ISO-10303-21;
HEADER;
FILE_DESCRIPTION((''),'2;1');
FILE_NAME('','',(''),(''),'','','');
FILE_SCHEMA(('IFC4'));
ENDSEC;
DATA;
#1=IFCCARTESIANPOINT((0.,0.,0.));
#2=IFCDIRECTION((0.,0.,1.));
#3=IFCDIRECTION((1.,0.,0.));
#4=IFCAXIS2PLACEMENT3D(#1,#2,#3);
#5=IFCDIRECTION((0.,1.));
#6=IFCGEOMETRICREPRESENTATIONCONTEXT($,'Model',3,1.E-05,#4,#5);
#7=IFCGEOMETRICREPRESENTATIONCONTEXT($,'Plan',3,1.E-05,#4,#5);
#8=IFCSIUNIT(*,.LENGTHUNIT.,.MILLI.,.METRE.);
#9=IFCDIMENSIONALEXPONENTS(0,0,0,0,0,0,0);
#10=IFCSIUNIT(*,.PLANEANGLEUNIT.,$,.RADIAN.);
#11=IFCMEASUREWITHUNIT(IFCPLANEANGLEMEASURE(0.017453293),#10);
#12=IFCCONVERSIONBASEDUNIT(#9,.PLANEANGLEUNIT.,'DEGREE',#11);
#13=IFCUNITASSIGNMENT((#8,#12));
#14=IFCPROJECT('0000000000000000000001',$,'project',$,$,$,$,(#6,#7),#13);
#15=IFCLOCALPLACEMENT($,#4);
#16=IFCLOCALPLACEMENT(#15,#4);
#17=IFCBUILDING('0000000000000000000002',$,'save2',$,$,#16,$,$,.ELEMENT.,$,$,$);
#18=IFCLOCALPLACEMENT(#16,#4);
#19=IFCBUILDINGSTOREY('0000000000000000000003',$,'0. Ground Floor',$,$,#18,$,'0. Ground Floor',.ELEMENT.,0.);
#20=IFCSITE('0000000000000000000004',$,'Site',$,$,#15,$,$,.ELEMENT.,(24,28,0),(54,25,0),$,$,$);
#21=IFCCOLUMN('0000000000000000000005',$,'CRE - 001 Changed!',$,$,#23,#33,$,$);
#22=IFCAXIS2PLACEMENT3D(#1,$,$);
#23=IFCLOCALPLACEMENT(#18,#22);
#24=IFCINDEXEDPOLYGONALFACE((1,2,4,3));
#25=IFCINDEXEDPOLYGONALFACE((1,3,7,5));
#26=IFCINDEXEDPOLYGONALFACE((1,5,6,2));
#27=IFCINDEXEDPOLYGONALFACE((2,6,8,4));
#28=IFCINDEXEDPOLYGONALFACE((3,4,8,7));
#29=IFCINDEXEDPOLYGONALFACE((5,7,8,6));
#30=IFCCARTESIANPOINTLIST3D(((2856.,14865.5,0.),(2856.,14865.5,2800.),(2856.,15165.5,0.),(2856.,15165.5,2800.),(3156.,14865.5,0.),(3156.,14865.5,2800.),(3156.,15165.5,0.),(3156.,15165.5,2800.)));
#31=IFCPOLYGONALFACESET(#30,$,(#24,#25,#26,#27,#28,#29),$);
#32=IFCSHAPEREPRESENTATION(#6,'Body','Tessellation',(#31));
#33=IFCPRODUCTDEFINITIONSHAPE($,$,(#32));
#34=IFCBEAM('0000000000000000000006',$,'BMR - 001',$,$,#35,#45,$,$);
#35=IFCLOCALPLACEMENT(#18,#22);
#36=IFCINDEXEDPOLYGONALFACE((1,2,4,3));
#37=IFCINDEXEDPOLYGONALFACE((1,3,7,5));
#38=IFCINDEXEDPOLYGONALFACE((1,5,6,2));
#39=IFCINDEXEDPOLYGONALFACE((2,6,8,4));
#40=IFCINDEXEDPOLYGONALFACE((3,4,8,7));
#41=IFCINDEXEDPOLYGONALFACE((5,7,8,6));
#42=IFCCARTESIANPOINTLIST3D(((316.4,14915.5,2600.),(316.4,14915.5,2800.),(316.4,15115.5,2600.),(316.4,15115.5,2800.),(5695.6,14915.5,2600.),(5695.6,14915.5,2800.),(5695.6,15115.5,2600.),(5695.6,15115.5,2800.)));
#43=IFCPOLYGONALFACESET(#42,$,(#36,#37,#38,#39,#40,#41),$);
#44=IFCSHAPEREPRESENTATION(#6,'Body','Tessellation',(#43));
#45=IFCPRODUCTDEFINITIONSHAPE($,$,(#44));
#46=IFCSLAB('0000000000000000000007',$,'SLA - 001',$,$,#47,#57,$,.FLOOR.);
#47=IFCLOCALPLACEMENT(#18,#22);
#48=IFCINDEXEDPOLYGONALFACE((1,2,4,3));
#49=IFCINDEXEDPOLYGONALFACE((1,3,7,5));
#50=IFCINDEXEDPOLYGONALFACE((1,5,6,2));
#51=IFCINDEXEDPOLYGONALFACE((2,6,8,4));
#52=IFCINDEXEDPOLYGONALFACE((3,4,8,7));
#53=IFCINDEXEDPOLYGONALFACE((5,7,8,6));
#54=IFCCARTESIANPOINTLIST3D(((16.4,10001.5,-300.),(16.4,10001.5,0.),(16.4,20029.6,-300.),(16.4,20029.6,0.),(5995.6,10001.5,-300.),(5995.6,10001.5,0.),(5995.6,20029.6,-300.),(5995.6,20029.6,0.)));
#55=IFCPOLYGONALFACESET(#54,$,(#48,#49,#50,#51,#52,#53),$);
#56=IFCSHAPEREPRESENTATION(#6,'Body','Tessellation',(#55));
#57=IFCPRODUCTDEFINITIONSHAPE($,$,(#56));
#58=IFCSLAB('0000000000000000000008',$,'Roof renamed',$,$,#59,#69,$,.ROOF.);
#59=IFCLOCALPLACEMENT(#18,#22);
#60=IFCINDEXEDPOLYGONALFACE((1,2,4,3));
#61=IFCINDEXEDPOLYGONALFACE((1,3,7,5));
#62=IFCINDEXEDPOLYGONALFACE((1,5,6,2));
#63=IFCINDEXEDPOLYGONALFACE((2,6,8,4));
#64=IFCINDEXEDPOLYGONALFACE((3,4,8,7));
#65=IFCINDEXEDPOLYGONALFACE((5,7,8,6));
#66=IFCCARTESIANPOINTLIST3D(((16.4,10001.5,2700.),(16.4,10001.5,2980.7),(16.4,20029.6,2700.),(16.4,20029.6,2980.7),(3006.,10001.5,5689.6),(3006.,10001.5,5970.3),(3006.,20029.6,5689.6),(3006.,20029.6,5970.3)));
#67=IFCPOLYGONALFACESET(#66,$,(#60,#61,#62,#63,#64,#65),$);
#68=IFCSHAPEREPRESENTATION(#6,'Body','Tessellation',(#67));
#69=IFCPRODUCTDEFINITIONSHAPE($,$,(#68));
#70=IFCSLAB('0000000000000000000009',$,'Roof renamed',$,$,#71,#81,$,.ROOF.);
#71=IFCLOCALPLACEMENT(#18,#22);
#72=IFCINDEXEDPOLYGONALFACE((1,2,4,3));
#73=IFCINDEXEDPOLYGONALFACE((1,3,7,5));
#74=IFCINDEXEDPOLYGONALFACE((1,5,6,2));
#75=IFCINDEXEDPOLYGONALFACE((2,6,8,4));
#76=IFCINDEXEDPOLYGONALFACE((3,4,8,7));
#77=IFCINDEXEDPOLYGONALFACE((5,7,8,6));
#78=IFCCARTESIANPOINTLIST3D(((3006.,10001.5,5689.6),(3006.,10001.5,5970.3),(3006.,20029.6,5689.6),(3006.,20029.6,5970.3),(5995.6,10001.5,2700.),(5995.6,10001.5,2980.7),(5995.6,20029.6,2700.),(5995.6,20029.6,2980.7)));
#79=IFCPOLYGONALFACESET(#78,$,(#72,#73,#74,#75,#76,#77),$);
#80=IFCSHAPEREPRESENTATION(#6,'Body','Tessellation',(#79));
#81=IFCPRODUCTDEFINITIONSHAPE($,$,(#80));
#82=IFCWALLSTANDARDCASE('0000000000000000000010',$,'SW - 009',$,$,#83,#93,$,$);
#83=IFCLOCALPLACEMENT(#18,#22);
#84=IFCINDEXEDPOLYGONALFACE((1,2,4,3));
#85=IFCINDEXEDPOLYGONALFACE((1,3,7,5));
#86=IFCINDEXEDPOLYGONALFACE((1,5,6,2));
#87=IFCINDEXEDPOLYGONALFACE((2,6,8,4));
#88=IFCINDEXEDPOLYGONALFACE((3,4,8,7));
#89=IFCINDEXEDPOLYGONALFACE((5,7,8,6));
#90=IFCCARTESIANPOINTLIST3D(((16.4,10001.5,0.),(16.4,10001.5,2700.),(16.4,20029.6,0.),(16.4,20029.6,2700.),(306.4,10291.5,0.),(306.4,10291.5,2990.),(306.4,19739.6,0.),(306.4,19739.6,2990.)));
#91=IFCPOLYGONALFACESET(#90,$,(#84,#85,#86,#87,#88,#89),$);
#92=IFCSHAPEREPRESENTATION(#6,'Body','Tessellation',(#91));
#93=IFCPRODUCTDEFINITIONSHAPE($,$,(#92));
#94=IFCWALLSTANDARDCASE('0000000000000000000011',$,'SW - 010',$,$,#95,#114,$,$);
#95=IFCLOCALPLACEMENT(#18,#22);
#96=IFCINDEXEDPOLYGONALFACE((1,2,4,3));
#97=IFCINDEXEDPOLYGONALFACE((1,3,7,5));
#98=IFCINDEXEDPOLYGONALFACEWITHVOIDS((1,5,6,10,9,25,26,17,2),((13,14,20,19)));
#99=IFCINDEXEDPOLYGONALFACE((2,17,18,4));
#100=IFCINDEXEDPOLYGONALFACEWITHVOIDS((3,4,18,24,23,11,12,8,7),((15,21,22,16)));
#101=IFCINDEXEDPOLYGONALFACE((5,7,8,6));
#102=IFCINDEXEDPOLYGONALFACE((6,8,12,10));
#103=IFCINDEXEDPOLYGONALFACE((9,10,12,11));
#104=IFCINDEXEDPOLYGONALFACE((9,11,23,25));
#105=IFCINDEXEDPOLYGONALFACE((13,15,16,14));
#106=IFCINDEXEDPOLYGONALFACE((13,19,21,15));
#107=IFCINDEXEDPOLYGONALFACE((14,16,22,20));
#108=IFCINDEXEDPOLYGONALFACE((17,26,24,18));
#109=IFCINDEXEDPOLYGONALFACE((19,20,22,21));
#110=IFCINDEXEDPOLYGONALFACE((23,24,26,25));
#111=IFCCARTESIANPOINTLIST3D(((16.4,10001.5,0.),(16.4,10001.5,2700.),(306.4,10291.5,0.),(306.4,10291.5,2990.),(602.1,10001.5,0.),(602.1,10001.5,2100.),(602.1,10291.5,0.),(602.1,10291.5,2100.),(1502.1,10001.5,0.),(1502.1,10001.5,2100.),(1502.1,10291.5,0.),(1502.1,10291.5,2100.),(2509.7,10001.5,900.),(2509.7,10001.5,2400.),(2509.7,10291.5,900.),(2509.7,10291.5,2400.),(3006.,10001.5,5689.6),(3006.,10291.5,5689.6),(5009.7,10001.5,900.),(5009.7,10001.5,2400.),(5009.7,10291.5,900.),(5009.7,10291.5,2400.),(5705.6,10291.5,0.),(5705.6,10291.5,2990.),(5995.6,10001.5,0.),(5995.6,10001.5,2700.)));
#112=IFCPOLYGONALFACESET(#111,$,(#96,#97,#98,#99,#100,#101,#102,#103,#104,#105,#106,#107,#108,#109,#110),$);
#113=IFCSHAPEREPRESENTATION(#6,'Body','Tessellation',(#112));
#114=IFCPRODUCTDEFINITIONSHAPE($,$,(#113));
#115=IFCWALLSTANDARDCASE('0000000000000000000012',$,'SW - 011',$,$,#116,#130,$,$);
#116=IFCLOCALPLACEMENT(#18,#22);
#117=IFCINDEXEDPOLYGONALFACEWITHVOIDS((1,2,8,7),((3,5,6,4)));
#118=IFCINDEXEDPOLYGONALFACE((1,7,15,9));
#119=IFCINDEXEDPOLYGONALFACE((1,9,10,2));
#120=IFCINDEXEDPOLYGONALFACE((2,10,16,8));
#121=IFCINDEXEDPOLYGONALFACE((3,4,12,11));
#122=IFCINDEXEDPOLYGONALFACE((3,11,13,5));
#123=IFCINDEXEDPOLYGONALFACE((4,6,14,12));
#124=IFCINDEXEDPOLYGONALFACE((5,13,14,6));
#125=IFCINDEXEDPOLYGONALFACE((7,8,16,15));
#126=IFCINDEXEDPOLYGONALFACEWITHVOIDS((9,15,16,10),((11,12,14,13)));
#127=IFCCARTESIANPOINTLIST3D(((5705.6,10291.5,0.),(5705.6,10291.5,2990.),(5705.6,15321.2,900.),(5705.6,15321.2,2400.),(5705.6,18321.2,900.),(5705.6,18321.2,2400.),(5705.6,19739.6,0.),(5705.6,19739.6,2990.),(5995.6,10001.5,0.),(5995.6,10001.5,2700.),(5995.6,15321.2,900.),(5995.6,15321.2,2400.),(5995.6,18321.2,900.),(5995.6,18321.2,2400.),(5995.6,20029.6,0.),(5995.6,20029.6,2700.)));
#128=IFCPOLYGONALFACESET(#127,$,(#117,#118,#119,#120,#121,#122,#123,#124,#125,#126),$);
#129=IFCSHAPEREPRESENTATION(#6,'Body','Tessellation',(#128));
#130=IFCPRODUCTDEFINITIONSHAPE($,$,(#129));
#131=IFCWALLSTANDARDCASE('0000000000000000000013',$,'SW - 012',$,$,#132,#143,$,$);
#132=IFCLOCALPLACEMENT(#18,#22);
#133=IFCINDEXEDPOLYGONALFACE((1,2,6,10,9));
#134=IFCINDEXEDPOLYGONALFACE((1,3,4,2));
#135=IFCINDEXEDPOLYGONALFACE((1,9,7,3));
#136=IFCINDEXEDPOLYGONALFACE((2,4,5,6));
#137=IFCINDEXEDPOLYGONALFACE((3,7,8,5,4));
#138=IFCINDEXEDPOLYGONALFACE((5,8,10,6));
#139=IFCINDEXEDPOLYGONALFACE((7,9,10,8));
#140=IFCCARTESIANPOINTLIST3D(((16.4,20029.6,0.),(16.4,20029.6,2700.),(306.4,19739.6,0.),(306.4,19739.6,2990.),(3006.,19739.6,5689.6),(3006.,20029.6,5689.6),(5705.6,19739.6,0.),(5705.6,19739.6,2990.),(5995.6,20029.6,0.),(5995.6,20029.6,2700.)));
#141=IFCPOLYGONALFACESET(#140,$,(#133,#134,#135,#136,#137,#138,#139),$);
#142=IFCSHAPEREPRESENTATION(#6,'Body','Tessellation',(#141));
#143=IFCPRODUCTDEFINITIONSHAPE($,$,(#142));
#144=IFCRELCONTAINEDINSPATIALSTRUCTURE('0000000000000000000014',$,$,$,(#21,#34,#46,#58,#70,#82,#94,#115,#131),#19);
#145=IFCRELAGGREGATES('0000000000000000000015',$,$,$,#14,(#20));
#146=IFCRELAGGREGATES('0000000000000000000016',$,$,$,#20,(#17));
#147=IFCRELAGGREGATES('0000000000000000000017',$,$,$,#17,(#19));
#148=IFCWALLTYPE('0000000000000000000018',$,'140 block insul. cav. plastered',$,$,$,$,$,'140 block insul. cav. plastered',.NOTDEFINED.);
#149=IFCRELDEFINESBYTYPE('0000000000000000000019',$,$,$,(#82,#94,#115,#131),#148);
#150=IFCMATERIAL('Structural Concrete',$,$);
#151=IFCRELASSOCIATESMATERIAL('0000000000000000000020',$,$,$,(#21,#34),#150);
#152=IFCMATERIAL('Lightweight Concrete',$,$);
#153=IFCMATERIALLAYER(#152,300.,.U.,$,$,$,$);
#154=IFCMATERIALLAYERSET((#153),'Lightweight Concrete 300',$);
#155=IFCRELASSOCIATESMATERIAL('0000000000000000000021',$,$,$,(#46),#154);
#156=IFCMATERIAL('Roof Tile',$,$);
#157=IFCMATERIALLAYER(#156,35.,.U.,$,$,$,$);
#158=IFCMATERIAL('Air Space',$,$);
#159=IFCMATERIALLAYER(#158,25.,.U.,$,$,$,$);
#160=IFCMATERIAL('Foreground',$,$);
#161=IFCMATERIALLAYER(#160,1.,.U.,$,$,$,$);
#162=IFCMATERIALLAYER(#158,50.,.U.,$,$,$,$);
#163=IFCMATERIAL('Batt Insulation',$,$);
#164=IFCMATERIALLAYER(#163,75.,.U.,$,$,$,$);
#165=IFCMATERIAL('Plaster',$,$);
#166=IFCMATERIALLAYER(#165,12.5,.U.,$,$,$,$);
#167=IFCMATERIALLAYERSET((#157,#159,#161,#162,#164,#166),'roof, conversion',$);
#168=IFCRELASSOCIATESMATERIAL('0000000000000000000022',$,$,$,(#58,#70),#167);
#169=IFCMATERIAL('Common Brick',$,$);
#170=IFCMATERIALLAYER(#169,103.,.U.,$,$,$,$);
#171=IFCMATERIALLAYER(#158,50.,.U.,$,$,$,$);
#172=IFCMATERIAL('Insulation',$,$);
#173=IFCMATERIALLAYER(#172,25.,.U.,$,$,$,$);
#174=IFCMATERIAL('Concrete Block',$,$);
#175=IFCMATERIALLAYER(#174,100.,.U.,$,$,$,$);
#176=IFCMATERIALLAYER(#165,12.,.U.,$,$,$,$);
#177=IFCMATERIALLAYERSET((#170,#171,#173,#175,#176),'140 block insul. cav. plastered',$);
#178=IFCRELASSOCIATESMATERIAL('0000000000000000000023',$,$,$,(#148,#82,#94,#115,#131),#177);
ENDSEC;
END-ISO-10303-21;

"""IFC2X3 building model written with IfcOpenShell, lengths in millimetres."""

from ifc_helpers import new_model, entity, si_unit, converted_unit, direction, frame, frame_2d, origin_with_axes, origin_2d_with_axis, place, context, project, spatial, polyline, rectangle, outline, extrude, clip, halfspace, bounded_halfspace, material, layer, layer_set, layer_usage, type_object, element, save


model = new_model("IFC2X3")

# Units and contexts
model_context = context("Model", 3, precision=1e-05, world=origin_with_axes(), true_north=direction((0.0, 1.0)))
plan_context = context("Plan", 3, precision=1e-05, world=origin_with_axes(), true_north=direction((0.0, 1.0)))
ifc_project = project(units=[si_unit("LENGTHUNIT", "METRE", prefix="MILLI"), converted_unit("PLANEANGLEUNIT", "DEGREE", entity("IfcPlaneAngleMeasure", 0.017453293), si_unit("PLANEANGLEUNIT", "RADIAN"), dimensions=[0, 0, 0, 0, 0, 0, 0])], contexts=[model_context, plan_context])

# Site, building, storey
site_placement = place(None, origin_with_axes())
site = spatial("IfcSite", under=ifc_project, at=site_placement, Name="Site", CompositionType="ELEMENT", RefLatitude=(24, 28, 0), RefLongitude=(54, 25, 0))
building_placement = place(site_placement, origin_with_axes())
building = spatial("IfcBuilding", under=site, at=building_placement, Name="save2", CompositionType="ELEMENT")
storey_placement = place(building_placement, origin_with_axes())
storey = spatial("IfcBuildingStorey", under=building, at=storey_placement, Name="0. Ground Floor", LongName="0. Ground Floor", CompositionType="ELEMENT", Elevation=0.0)

# Column
ifc_material_1 = material(Name="Structural Concrete")
column_placement = place(storey_placement, frame((3006.0, 15015.5, 0.0), z_axis=(0.0, 0.0, 1.0), x_axis=(1.0, 0.0, 0.0)))
element("IfcColumn", 1, at=column_placement, inside=storey, material=ifc_material_1, Name="CRE - 001 Changed!", context=model_context, shape_type="SweptSolid", body=[
    extrude(rectangle(XDim=300.0, YDim=300.0, at=origin_2d_with_axis()), origin_with_axes(), (0.0, 0.0, 1.0), 2800.0),
])

# Beam
beam_placement = place(storey_placement, frame((316.4, 15015.5, 2800.0), z_axis=(0.0, 0.0, 1.0), x_axis=(0.0, -1.0, 0.0)))
element("IfcBeam", 2, at=beam_placement, inside=storey, material=ifc_material_1, Name="BMR - 001", context=model_context, shape_type="SweptSolid", body=[
    extrude(rectangle(XDim=200.0, YDim=200.0, at=frame_2d((-100.0, 0.0), x_axis=(1.0, 0.0))), frame((0.0, 0.0, 0.0), z_axis=(0.0, 1.0, 0.0), x_axis=(0.0, 0.0, 1.0)), (0.0, 0.0, 1.0), 5379.1),
])

# Slabs
ifc_material_2 = material(Name="Lightweight Concrete")
ifc_layer_1 = layer(ifc_material_2, 300.0, ventilated="UNKNOWN")
ifc_layer_set_1 = layer_set([ifc_layer_1], Name="Lightweight Concrete 300")
ifc_layer_usage_1 = layer_usage(ifc_layer_set_1, "AXIS3", "NEGATIVE", 300.0)
slab_1_placement = place(storey_placement, frame((16.4, 20029.6, -300.0), z_axis=(0.0, 0.0, 1.0), x_axis=(1.0, 0.0, 0.0)))
element("IfcSlab", 3, at=slab_1_placement, inside=storey, material=ifc_layer_usage_1, Name="SLA - 001", PredefinedType="FLOOR", context=model_context, shape_type="SweptSolid", body=[
    extrude(outline(polyline([(0.0, 0.0), (5979.1, 0.0), (5979.1, -10028.0), (0.0, -10028.0), (0.0, 0.0)])), origin_with_axes(), (0.0, 0.0, 1.0), 300.0),
])
ifc_material_3 = material(Name="Roof Tile")
ifc_layer_2 = layer(ifc_material_3, 35.0, ventilated="UNKNOWN")
ifc_material_4 = material(Name="Air Space")
ifc_layer_3 = layer(ifc_material_4, 25.0, ventilated="UNKNOWN")
ifc_material_5 = material(Name="Foreground")
ifc_layer_4 = layer(ifc_material_5, 1.0, ventilated="UNKNOWN")
ifc_layer_5 = layer(ifc_material_4, 50.0, ventilated="UNKNOWN")
ifc_material_6 = material(Name="Batt Insulation")
ifc_layer_6 = layer(ifc_material_6, 75.0, ventilated="UNKNOWN")
ifc_material_7 = material(Name="Plaster")
ifc_layer_7 = layer(ifc_material_7, 12.5, ventilated="UNKNOWN")
ifc_layer_set_2 = layer_set([ifc_layer_2, ifc_layer_3, ifc_layer_4, ifc_layer_5, ifc_layer_6, ifc_layer_7], Name="roof, conversion")
ifc_layer_usage_2 = layer_usage(ifc_layer_set_2, "AXIS3", "NEGATIVE", 198.5)
slab_2_placement = place(storey_placement, frame((16.4, 20029.6, 2700.0), z_axis=(-0.707107, 0.0, 0.707107), x_axis=(0.0, -1.0, 0.0)))
element("IfcSlab", 4, at=slab_2_placement, inside=storey, material=ifc_layer_usage_2, Name="Roof renamed", PredefinedType="ROOF", context=model_context, shape_type="SweptSolid", body=[
    extrude(outline(polyline([(0.0, 0.0), (0.0, 4227.9), (10028.0, 4227.9), (10028.0, 0.0), (0.0, 0.0)])), origin_with_axes(), (0.0, 0.707107, 0.707107), 280.7),
])
ifc_layer_usage_3 = layer_usage(ifc_layer_set_2, "AXIS3", "NEGATIVE", 198.5)
slab_3_placement = place(storey_placement, frame((5995.6, 10001.5, 2700.0), z_axis=(0.707107, 0.0, 0.707107), x_axis=(0.0, 1.0, 0.0)))
element("IfcSlab", 5, at=slab_3_placement, inside=storey, material=ifc_layer_usage_3, Name="Roof renamed", PredefinedType="ROOF", context=model_context, shape_type="SweptSolid", body=[
    extrude(outline(polyline([(0.0, 0.0), (10028.0, 0.0), (10028.0, 4227.9), (0.0, 4227.9), (0.0, 0.0)])), origin_with_axes(), (0.0, 0.707107, 0.707107), 280.7),
])

# Wall
ifc_material_8 = material(Name="Common Brick")
ifc_layer_8 = layer(ifc_material_8, 103.0, ventilated="UNKNOWN")
ifc_layer_9 = layer(ifc_material_4, 50.0, ventilated="UNKNOWN")
ifc_material_9 = material(Name="Insulation")
ifc_layer_10 = layer(ifc_material_9, 25.0, ventilated="UNKNOWN")
ifc_material_10 = material(Name="Concrete Block")
ifc_layer_11 = layer(ifc_material_10, 100.0, ventilated="UNKNOWN")
ifc_layer_12 = layer(ifc_material_7, 12.0, ventilated="UNKNOWN")
ifc_layer_set_3 = layer_set([ifc_layer_8, ifc_layer_9, ifc_layer_10, ifc_layer_11, ifc_layer_12], Name="140 block insul. cav. plastered")
ifc_layer_usage_4 = layer_usage(ifc_layer_set_3, "AXIS2", "POSITIVE", 0.0)
wall_type_1 = type_object("IfcWallType", Name="140 block insul. cav. plastered", ElementType="140 block insul. cav. plastered", PredefinedType="NOTDEFINED", material=ifc_layer_set_3)
wall_1_placement = place(storey_placement, frame((16.4, 20029.6, 0.0), z_axis=(0.0, 0.0, 1.0), x_axis=(0.0, -1.0, 0.0)))
element("IfcWallStandardCase", 6, at=wall_1_placement, inside=storey, type_object=wall_type_1, material=ifc_layer_usage_4, Name="SW - 009", context=model_context, shape_type="Clipping", body=[
    clip(extrude(outline(polyline([(0.0, 0.0), (10028.0, 0.0), (9738.0, 290.0), (290.0, 290.0), (0.0, 0.0)])), origin_with_axes(), (0.0, 0.0, 1.0), 6000.0), halfspace(frame((0.0, -1350.0, 1350.0), z_axis=(0.0, 0.707107, -0.707107), x_axis=(0.0, 0.707107, 0.707107)), True)),
])

# Wall, openings
ifc_layer_usage_5 = layer_usage(ifc_layer_set_3, "AXIS2", "POSITIVE", 0.0)
wall_2_placement = place(storey_placement, frame((16.4, 10001.5, 0.0), z_axis=(0.0, 0.0, 1.0), x_axis=(1.0, 0.0, 0.0)))
wall_2 = element("IfcWallStandardCase", 7, at=wall_2_placement, inside=storey, type_object=wall_type_1, material=ifc_layer_usage_5, Name="SW - 010", context=model_context, shape_type="Clipping", body=[
    clip(clip(extrude(outline(polyline([(0.0, 0.0), (5979.1, 0.0), (5689.1, 290.0), (290.0, 290.0), (0.0, 0.0)])), origin_with_axes(), (0.0, 0.0, 1.0), 6000.0), bounded_halfspace(frame((-1350.0, 0.0, 1350.0), z_axis=(0.707107, 0.0, -0.707107), x_axis=(0.0, 1.0, 0.0)), True, origin_with_axes(), polyline([(2989.6, -145.0), (2989.6, 435.0), (-10.0, 435.0), (-10.0, -145.0), (2989.6, -145.0)]))), bounded_halfspace(frame((4339.6, 0.0, 4339.6), z_axis=(-0.707107, 0.0, -0.707107), x_axis=(0.0, 1.0, 0.0)), True, origin_with_axes(), polyline([(2989.6, -145.0), (2989.6, 435.0), (5989.1, 435.0), (5989.1, -145.0), (2989.6, -145.0)]))),
])
opening_1_placement = place(wall_2_placement, frame((1035.6, 0.0, 0.0), z_axis=(0.0, 0.0, 1.0), x_axis=(1.0, 0.0, 0.0)))
element("IfcOpeningElement", 8, at=opening_1_placement, cuts=wall_2, ObjectType="Opening", context=model_context, shape_type="SweptSolid", body=[
    extrude(rectangle(XDim=900.0, YDim=2100.0, at=frame_2d((0.0, 1050.0), x_axis=(-1.0, 0.0))), frame((0.0, 0.0, 0.0), z_axis=(0.0, 1.0, 0.0), x_axis=(-1.0, 0.0, 0.0)), (0.0, 0.0, 1.0), 290.0),
])
opening_2_placement = place(wall_2_placement, frame((3743.3, 0.0, 900.0), z_axis=(0.0, 0.0, 1.0), x_axis=(1.0, 0.0, 0.0)))
element("IfcOpeningElement", 9, at=opening_2_placement, cuts=wall_2, ObjectType="Opening", context=model_context, shape_type="SweptSolid", body=[
    extrude(rectangle(XDim=2500.0, YDim=1500.0, at=frame_2d((0.0, 750.0), x_axis=(-1.0, 0.0))), frame((0.0, 0.0, 0.0), z_axis=(0.0, 1.0, 0.0), x_axis=(-1.0, 0.0, 0.0)), (0.0, 0.0, 1.0), 290.0),
])

# Wall, opening
ifc_layer_usage_6 = layer_usage(ifc_layer_set_3, "AXIS2", "POSITIVE", 0.0)
wall_3_placement = place(storey_placement, frame((5995.6, 10001.5, 0.0), z_axis=(0.0, 0.0, 1.0), x_axis=(0.0, 1.0, 0.0)))
wall_3 = element("IfcWallStandardCase", 10, at=wall_3_placement, inside=storey, type_object=wall_type_1, material=ifc_layer_usage_6, Name="SW - 011", context=model_context, shape_type="Clipping", body=[
    clip(extrude(outline(polyline([(0.0, 0.0), (10028.0, 0.0), (9738.0, 290.0), (290.0, 290.0), (0.0, 0.0)])), origin_with_axes(), (0.0, 0.0, 1.0), 6000.0), halfspace(frame((0.0, -1350.0, 1350.0), z_axis=(0.0, 0.707107, -0.707107), x_axis=(0.0, 0.707107, 0.707107)), True)),
])
opening_3_placement = place(wall_3_placement, frame((6819.7, 0.0, 900.0), z_axis=(0.0, 0.0, 1.0), x_axis=(1.0, 0.0, 0.0)))
element("IfcOpeningElement", 11, at=opening_3_placement, cuts=wall_3, ObjectType="Opening", context=model_context, shape_type="SweptSolid", body=[
    extrude(rectangle(XDim=3000.0, YDim=1500.0, at=frame_2d((0.0, 750.0), x_axis=(1.0, 0.0))), frame((0.0, 0.0, 0.0), z_axis=(0.0, 1.0, 0.0), x_axis=(-1.0, 0.0, 0.0)), (0.0, 0.0, 1.0), 290.0),
])

# Wall
ifc_layer_usage_7 = layer_usage(ifc_layer_set_3, "AXIS2", "POSITIVE", 0.0)
wall_4_placement = place(storey_placement, frame((5995.6, 20029.6, 0.0), z_axis=(0.0, 0.0, 1.0), x_axis=(-1.0, 0.0, 0.0)))
element("IfcWallStandardCase", 12, at=wall_4_placement, inside=storey, type_object=wall_type_1, material=ifc_layer_usage_7, Name="SW - 012", context=model_context, shape_type="Clipping", body=[
    clip(clip(extrude(outline(polyline([(0.0, 0.0), (5979.1, 0.0), (5689.1, 290.0), (290.0, 290.0), (0.0, 0.0)])), origin_with_axes(), (0.0, 0.0, 1.0), 6000.0), bounded_halfspace(frame((4339.6, 0.0, 4339.6), z_axis=(-0.707107, 0.0, -0.707107), x_axis=(0.0, 1.0, 0.0)), True, origin_with_axes(), polyline([(2989.6, -145.0), (2989.6, 435.0), (5989.1, 435.0), (5989.1, -145.0), (2989.6, -145.0)]))), bounded_halfspace(frame((-1350.0, 0.0, 1350.0), z_axis=(0.707107, 0.0, -0.707107), x_axis=(0.0, 1.0, 0.0)), True, origin_with_axes(), polyline([(2989.6, -145.0), (2989.6, 435.0), (-10.0, 435.0), (-10.0, -145.0), (2989.6, -145.0)]))),
])

save(model, "model.ifc")
